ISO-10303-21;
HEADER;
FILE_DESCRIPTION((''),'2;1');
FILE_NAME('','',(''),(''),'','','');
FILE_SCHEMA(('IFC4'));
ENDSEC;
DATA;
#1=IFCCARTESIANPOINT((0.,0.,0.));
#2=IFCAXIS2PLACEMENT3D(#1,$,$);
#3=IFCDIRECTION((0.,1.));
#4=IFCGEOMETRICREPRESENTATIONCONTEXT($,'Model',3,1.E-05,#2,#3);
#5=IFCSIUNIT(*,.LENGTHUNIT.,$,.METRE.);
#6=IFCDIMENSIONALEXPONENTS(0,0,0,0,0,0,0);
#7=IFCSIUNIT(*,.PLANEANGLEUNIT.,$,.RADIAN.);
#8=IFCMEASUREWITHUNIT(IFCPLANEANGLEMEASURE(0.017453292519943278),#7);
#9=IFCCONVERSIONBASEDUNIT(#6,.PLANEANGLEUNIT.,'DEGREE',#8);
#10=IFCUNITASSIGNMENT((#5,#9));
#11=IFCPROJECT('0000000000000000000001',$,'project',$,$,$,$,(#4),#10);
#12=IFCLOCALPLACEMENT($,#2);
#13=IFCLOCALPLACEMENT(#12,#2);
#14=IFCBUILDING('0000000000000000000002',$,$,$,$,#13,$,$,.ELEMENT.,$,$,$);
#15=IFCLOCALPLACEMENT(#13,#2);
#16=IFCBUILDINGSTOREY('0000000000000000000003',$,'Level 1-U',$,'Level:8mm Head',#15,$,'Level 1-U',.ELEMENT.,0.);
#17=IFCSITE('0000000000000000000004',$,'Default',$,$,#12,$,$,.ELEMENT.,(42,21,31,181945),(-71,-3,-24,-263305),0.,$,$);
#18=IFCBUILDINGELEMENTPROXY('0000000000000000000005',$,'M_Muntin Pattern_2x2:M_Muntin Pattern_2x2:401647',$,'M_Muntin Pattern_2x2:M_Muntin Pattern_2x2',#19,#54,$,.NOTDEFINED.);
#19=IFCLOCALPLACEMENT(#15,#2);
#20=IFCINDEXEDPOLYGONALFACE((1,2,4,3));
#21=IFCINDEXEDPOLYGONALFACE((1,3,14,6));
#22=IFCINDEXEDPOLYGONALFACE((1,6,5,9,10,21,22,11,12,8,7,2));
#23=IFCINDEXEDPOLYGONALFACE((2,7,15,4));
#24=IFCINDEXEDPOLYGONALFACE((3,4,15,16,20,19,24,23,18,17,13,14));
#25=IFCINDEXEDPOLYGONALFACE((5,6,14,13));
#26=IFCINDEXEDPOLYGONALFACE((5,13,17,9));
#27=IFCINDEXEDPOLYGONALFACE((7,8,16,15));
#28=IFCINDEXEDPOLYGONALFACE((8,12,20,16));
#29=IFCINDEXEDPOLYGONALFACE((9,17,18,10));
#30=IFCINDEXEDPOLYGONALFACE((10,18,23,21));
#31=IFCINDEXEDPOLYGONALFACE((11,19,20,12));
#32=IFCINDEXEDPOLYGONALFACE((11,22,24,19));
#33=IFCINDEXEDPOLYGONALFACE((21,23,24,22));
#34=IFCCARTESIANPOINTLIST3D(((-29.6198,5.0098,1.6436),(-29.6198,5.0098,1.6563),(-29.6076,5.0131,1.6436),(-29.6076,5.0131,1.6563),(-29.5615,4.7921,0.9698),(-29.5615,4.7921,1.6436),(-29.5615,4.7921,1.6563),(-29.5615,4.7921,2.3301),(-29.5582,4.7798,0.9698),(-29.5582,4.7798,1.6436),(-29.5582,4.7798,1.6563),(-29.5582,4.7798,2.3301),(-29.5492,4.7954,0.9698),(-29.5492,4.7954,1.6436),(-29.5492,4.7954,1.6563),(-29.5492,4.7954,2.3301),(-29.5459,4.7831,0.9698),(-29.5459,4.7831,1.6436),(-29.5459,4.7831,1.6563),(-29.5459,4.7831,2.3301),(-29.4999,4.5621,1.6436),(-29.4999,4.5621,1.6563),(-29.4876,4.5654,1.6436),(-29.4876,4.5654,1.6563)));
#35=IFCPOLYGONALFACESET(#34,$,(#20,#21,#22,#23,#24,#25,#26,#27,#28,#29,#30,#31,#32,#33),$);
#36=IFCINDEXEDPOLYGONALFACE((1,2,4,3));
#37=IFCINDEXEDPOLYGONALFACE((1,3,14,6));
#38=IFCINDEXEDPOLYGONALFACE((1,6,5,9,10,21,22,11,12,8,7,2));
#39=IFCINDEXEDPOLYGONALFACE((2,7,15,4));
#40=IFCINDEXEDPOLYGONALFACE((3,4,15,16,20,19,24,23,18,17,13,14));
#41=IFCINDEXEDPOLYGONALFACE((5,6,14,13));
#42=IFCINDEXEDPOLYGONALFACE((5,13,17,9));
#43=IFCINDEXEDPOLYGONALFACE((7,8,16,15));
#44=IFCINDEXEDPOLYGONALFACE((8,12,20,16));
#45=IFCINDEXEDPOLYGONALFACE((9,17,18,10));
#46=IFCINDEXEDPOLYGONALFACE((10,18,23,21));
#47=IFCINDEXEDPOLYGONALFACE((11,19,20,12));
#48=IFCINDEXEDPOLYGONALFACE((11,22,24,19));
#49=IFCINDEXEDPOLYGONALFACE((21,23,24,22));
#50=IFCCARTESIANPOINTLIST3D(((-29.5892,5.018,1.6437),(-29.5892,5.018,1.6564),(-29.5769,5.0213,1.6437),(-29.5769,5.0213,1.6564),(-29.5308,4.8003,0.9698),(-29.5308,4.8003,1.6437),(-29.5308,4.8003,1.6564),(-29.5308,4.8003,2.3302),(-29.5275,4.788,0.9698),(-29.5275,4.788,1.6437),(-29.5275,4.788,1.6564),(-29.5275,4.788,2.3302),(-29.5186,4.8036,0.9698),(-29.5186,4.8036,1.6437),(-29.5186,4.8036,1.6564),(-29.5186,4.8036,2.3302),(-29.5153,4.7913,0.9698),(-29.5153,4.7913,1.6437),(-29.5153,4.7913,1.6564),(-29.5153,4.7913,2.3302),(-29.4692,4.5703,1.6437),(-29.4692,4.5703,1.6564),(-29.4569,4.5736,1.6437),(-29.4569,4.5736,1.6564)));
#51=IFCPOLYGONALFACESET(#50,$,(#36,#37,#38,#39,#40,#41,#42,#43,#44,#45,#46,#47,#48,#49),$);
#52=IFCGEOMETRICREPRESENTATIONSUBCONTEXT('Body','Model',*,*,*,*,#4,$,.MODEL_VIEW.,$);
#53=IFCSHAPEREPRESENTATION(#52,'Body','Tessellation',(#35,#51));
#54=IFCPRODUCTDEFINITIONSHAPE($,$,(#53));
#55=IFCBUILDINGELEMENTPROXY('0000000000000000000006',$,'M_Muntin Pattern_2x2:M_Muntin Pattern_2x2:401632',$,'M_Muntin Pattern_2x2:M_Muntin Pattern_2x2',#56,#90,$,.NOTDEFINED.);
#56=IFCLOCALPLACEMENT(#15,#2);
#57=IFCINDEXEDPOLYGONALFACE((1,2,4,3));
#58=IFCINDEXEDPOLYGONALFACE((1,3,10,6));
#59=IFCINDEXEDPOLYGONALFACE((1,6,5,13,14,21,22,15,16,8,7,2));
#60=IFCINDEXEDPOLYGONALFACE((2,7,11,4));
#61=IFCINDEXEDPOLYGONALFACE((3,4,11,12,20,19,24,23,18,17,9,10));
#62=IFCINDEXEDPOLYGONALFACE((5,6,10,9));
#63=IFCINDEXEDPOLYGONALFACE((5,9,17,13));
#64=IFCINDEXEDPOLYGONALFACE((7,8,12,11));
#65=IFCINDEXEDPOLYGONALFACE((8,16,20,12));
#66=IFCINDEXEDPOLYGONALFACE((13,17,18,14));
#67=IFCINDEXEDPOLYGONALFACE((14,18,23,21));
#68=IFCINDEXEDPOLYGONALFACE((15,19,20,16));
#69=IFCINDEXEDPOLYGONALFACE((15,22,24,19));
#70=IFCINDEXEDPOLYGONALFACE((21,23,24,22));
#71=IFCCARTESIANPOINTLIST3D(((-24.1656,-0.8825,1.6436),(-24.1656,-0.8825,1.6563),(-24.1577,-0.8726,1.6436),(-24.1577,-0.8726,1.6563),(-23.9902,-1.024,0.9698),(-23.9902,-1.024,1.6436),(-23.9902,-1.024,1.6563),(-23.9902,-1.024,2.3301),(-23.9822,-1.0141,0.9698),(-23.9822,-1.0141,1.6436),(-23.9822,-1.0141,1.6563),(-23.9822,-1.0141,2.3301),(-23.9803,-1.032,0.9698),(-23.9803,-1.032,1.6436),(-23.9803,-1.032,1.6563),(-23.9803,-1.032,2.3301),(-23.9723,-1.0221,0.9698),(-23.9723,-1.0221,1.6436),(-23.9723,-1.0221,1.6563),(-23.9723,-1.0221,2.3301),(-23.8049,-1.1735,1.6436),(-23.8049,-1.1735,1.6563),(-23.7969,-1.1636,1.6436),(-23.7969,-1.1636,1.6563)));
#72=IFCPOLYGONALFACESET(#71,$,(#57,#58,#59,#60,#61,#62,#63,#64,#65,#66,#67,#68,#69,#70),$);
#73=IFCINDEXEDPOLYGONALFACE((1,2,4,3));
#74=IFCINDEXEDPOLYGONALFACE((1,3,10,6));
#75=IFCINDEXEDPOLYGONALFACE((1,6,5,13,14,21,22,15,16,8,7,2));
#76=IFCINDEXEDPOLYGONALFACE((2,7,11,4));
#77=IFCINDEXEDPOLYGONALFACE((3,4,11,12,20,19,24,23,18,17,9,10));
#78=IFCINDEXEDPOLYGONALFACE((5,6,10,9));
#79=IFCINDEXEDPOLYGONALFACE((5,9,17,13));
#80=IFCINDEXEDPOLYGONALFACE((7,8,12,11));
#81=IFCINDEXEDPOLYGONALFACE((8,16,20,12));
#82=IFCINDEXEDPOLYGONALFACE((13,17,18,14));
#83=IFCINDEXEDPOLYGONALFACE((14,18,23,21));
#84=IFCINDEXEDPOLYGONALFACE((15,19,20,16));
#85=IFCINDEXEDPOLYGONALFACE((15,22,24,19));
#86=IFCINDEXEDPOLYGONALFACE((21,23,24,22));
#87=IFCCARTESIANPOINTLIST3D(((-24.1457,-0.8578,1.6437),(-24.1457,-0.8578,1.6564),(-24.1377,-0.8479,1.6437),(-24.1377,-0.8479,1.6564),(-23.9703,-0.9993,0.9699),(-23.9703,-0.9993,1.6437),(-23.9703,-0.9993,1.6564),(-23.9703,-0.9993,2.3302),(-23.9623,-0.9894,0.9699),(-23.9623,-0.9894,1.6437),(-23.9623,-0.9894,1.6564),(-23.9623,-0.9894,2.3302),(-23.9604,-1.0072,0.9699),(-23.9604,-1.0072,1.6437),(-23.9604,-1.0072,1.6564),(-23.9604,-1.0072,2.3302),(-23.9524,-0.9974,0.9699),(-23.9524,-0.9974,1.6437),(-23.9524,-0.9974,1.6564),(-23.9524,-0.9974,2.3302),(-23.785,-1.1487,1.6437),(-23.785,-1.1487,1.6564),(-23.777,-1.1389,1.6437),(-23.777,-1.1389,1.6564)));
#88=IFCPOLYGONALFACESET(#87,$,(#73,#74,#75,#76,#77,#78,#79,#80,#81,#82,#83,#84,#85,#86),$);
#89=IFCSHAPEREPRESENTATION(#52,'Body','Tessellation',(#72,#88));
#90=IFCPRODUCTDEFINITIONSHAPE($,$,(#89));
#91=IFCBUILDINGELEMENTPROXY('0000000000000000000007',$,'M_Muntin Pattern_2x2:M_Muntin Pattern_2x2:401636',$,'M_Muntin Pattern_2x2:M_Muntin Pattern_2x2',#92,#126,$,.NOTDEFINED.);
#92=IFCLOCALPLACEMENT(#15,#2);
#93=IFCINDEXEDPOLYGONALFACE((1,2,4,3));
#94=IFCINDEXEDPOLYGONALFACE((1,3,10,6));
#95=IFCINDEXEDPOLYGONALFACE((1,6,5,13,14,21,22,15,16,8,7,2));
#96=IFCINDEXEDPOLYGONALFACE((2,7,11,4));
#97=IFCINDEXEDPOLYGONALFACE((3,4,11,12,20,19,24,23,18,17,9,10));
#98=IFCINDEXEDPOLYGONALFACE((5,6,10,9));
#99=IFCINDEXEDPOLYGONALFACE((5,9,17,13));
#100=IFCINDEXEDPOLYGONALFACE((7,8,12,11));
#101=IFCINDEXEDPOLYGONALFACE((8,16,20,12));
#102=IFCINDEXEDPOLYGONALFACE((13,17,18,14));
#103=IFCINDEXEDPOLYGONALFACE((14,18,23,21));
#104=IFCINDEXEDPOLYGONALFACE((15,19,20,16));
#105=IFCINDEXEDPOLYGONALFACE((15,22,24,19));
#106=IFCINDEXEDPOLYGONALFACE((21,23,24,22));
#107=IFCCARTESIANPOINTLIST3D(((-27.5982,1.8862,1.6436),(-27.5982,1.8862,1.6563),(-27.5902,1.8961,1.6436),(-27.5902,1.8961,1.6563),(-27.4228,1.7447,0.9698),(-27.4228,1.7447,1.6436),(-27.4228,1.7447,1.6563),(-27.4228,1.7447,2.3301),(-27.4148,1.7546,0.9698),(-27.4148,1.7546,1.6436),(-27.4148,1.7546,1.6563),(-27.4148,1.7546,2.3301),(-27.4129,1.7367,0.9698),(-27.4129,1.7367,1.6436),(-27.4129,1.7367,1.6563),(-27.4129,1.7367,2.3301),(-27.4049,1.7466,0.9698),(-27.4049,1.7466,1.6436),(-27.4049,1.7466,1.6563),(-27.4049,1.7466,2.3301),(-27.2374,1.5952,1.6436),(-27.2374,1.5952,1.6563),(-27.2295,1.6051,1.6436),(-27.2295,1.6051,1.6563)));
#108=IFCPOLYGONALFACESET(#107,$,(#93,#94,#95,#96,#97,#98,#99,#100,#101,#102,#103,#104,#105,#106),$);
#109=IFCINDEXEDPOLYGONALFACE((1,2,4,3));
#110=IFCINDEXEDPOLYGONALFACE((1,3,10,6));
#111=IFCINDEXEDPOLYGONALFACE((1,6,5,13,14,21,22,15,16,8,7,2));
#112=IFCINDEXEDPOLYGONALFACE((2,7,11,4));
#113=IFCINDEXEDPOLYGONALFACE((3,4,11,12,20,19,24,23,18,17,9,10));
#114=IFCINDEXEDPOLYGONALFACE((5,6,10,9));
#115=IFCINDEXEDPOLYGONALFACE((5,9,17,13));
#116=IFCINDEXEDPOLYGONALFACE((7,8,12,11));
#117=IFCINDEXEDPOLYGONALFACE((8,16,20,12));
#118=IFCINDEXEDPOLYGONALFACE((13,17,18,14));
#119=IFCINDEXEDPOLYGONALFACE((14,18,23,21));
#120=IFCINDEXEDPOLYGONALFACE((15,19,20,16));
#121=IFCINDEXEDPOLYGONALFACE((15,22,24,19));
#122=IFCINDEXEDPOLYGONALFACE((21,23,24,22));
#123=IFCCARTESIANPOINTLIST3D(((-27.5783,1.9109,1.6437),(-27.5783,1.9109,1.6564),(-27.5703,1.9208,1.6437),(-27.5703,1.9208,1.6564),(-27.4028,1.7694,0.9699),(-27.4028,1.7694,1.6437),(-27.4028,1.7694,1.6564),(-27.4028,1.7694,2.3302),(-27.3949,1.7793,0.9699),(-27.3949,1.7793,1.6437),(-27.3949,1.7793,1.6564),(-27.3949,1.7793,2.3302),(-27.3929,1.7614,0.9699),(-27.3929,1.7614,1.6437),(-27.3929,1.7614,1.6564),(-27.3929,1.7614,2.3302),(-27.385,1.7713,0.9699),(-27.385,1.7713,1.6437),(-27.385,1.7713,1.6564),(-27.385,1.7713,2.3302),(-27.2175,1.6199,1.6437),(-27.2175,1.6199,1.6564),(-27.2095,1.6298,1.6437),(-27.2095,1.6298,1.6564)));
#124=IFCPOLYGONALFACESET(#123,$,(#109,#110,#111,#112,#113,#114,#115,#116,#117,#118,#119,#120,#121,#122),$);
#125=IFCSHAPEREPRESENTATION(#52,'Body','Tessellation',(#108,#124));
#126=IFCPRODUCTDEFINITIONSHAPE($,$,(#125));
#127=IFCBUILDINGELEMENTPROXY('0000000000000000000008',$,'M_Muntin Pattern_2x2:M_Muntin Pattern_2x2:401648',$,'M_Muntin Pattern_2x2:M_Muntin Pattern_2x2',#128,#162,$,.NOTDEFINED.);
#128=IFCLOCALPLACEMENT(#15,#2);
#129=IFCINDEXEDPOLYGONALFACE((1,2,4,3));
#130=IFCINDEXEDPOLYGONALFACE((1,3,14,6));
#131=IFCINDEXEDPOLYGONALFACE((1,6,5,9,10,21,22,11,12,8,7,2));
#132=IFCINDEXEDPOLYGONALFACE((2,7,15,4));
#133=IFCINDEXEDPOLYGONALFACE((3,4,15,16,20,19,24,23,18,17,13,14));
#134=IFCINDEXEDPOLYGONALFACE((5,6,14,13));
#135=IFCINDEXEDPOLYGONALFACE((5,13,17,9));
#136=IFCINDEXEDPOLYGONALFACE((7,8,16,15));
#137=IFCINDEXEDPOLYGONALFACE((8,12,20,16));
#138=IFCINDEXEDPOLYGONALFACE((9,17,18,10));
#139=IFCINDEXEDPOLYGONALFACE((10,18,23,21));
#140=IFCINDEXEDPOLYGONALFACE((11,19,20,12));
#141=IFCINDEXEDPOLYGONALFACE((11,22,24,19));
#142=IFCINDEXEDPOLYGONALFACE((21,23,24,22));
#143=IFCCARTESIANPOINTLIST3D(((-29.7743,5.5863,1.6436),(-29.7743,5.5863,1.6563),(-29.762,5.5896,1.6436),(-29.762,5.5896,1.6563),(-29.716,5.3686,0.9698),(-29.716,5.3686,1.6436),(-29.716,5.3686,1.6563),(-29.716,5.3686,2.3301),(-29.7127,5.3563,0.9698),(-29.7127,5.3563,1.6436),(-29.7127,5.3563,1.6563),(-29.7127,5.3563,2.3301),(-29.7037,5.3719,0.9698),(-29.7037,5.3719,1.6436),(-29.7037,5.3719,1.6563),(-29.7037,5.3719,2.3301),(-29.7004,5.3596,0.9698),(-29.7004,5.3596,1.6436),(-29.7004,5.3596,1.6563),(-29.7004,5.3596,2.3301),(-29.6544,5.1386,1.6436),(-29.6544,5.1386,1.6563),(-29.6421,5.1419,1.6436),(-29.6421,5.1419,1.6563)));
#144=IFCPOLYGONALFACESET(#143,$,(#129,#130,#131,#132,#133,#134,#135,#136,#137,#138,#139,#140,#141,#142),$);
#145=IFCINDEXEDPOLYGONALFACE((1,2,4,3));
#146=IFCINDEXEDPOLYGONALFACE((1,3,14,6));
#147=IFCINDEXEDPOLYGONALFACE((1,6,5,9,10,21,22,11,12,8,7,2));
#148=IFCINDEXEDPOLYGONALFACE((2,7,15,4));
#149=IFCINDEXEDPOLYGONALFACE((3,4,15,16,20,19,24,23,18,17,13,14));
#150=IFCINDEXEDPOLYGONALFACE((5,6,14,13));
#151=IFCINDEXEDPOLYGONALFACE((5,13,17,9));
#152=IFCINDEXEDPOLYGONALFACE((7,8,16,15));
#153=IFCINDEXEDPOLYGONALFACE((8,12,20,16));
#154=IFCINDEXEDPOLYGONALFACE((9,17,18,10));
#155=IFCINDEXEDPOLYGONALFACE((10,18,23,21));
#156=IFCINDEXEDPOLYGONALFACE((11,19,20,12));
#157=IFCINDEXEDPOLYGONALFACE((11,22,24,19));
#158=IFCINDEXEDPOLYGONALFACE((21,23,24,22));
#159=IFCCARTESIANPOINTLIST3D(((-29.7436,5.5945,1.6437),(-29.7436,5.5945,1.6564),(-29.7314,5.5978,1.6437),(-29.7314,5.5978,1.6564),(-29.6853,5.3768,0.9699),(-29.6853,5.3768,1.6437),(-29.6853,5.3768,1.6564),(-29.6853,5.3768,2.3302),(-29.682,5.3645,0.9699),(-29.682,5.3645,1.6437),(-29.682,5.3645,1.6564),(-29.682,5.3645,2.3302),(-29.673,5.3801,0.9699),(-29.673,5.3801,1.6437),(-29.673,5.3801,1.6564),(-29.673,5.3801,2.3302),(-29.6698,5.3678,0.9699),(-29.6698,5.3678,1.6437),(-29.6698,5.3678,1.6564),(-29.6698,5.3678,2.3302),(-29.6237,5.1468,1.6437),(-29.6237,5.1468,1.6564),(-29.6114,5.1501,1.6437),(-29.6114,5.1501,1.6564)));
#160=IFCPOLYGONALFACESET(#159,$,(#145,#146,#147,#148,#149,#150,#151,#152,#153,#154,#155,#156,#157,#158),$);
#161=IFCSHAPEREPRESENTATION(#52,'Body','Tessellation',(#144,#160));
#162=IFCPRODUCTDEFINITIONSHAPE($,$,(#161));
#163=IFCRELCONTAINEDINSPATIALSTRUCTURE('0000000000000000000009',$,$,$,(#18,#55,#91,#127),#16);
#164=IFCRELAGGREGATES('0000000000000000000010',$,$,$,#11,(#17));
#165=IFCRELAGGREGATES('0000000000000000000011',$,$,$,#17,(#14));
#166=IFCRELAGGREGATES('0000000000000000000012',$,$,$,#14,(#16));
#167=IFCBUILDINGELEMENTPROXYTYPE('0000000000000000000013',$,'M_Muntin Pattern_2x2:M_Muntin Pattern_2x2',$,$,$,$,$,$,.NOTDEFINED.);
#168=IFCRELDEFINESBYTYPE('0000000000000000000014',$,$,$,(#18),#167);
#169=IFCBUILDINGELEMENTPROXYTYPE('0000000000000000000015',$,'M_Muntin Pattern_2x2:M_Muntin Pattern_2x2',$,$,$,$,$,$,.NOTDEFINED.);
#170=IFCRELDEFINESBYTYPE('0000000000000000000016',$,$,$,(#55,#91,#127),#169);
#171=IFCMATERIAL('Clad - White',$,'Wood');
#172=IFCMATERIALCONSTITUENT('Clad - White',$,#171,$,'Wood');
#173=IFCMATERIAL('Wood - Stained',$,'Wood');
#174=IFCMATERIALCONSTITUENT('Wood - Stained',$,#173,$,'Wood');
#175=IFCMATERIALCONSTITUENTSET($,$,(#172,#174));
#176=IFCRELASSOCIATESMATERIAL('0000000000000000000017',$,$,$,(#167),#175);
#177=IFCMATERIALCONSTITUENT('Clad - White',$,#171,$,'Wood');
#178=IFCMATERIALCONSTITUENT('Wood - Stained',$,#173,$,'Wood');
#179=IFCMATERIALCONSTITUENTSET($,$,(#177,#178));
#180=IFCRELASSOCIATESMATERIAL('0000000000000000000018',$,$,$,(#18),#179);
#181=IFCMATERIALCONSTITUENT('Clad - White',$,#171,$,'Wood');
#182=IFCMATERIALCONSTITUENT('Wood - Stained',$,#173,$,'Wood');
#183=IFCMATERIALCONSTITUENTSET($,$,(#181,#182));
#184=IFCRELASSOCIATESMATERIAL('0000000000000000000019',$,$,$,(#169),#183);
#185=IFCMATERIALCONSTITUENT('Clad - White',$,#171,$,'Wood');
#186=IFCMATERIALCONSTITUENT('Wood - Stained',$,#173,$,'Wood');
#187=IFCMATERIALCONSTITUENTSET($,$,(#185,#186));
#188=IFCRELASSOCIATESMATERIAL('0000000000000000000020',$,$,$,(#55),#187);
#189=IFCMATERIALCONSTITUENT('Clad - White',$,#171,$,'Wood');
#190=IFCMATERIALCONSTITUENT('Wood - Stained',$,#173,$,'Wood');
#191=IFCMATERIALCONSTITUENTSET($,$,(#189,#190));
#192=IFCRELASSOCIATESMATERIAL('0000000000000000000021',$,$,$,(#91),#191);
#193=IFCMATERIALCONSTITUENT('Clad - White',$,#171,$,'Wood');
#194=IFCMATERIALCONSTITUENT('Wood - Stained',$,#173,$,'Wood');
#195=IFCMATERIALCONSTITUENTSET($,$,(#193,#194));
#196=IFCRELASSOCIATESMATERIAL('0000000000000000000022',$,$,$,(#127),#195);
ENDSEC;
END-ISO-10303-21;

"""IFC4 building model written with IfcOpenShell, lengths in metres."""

from ifc_helpers import new_model, entity, si_unit, converted_unit, direction, frame, origin, place, context, subcontext, project, spatial, polyline, outline, extrude, source, transform, mapped, material, constituent, constituent_set, type_object, type_shapes, element, save


model = new_model("IFC4")

# Units and contexts
model_context = context("Model", 3, precision=1e-05, world=origin(), true_north=direction((0.0, 1.0)))
body_context = subcontext(model_context, "Body", "Model", "MODEL_VIEW")
ifc_project = project(units=[si_unit("LENGTHUNIT", "METRE"), converted_unit("PLANEANGLEUNIT", "DEGREE", entity("IfcPlaneAngleMeasure", 0.017453292519943278), si_unit("PLANEANGLEUNIT", "RADIAN"), dimensions=[0, 0, 0, 0, 0, 0, 0])], contexts=[model_context])

# Site, building, storey
site_placement = place(None, origin())
site = spatial("IfcSite", under=ifc_project, at=site_placement, Name="Default", CompositionType="ELEMENT", RefLatitude=(42, 21, 31, 181945), RefLongitude=(-71, -3, -24, -263305), RefElevation=0.0)
building_placement = place(site_placement, origin())
building = spatial("IfcBuilding", under=site, at=building_placement, CompositionType="ELEMENT")
storey_placement = place(building_placement, origin())
storey = spatial("IfcBuildingStorey", under=building, at=storey_placement, Name="Level 1-U", ObjectType="Level:8mm Head", LongName="Level 1-U", CompositionType="ELEMENT", Elevation=0.0)

# Building element proxies
ifc_material_1 = material(Name="Clad - White", Category="Wood")
ifc_material_2 = material(Name="Wood - Stained", Category="Wood")
ifc_constituent_1 = constituent(ifc_material_1, Name="Clad - White", Category="Wood")
ifc_constituent_2 = constituent(ifc_material_2, Name="Wood - Stained", Category="Wood")
ifc_constituent_set_1 = constituent_set(constituents=[ifc_constituent_1, ifc_constituent_2])
building_element_proxy_type_1 = type_object("IfcBuildingElementProxyType", Name="M_Muntin Pattern_2x2:M_Muntin Pattern_2x2", PredefinedType="NOTDEFINED", material=ifc_constituent_set_1)
shared_shape_1 = source(origin(), body_context, "Body", "SweptSolid", [
    extrude(outline(polyline([(0.0064, -0.0064), (0.6801, -0.0064), (0.6801, 0.0063), (0.0064, 0.0063), (0.0064, 0.2317), (-0.0063, 0.2317), (-0.0063, 0.0063), (-0.6802, 0.0063), (-0.6802, -0.0064), (-0.0063, -0.0064), (-0.0063, -0.2317), (0.0064, -0.2317), (0.0064, -0.0064)])), frame((0.0, 0.0095, 0.6801), z_axis=(0.0, 1.0, 0.0), x_axis=(0.0, 0.0, 1.0)), (0.0, 0.0, 1.0), 0.0127),
    extrude(outline(polyline([(0.0064, -0.0064), (0.6802, -0.0064), (0.6802, 0.0063), (0.0064, 0.0063), (0.0064, 0.2317), (-0.0063, 0.2317), (-0.0063, 0.0063), (-0.6802, 0.0063), (-0.6802, -0.0064), (-0.0063, -0.0064), (-0.0063, -0.2317), (0.0064, -0.2317), (0.0064, -0.0064)])), frame((0.0, -0.0222, 0.6802), z_axis=(0.0, 1.0, 0.0), x_axis=(0.0, 0.0, 1.0)), (0.0, 0.0, 1.0), 0.0127),
])
type_shapes(building_element_proxy_type_1, [shared_shape_1])
ifc_constituent_3 = constituent(ifc_material_1, Name="Clad - White", Category="Wood")
ifc_constituent_4 = constituent(ifc_material_2, Name="Wood - Stained", Category="Wood")
ifc_constituent_set_2 = constituent_set(constituents=[ifc_constituent_3, ifc_constituent_4])
proxy_1_placement = place(storey_placement, frame((-29.5384, 4.7917, 0.9698), z_axis=(0.0, 0.0, 1.0), x_axis=(-0.258819, 0.965926, 0.0)))
element("IfcBuildingElementProxy", 1, at=proxy_1_placement, inside=storey, type_object=building_element_proxy_type_1, material=ifc_constituent_set_2, Name="M_Muntin Pattern_2x2:M_Muntin Pattern_2x2:401647", ObjectType="M_Muntin Pattern_2x2:M_Muntin Pattern_2x2", PredefinedType="NOTDEFINED", context=body_context, shape_type="MappedRepresentation", body=[
    mapped(shared_shape_1, transform((0.0, 0.0, 0.0), scale=1.0)),
])
ifc_constituent_5 = constituent(ifc_material_1, Name="Clad - White", Category="Wood")
ifc_constituent_6 = constituent(ifc_material_2, Name="Wood - Stained", Category="Wood")
ifc_constituent_set_3 = constituent_set(constituents=[ifc_constituent_5, ifc_constituent_6])
ifc_constituent_7 = constituent(ifc_material_1, Name="Clad - White", Category="Wood")
ifc_constituent_8 = constituent(ifc_material_2, Name="Wood - Stained", Category="Wood")
ifc_constituent_set_4 = constituent_set(constituents=[ifc_constituent_7, ifc_constituent_8])
building_element_proxy_type_2 = type_object("IfcBuildingElementProxyType", Name="M_Muntin Pattern_2x2:M_Muntin Pattern_2x2", PredefinedType="NOTDEFINED", material=ifc_constituent_set_4)
shared_shape_2 = source(origin(), body_context, "Body", "SweptSolid", [
    extrude(outline(polyline([(0.0064, -0.0064), (0.6801, -0.0064), (0.6801, 0.0063), (0.0064, 0.0063), (0.0064, 0.2317), (-0.0063, 0.2317), (-0.0063, 0.0063), (-0.6802, 0.0063), (-0.6802, -0.0064), (-0.0063, -0.0064), (-0.0063, -0.2317), (0.0064, -0.2317), (0.0064, -0.0064)])), frame((0.0, -0.0222, 0.6801), z_axis=(0.0, 1.0, 0.0), x_axis=(0.0, 0.0, 1.0)), (0.0, 0.0, 1.0), 0.0127),
    extrude(outline(polyline([(0.0064, -0.0064), (0.6802, -0.0064), (0.6802, 0.0063), (0.0064, 0.0063), (0.0064, 0.2317), (-0.0063, 0.2317), (-0.0063, 0.0063), (-0.6802, 0.0063), (-0.6802, -0.0064), (-0.0063, -0.0064), (-0.0063, -0.2317), (0.0064, -0.2317), (0.0064, -0.0064)])), frame((0.0, 0.0095, 0.6802), z_axis=(0.0, 1.0, 0.0), x_axis=(0.0, 0.0, 1.0)), (0.0, 0.0, 1.0), 0.0127),
])
type_shapes(building_element_proxy_type_2, [shared_shape_2])
proxy_2_placement = place(storey_placement, frame((-23.9713, -1.0107, 0.9699), z_axis=(0.0, 0.0, 1.0), x_axis=(0.778359, -0.62782, 0.0)))
element("IfcBuildingElementProxy", 2, at=proxy_2_placement, inside=storey, type_object=building_element_proxy_type_2, material=ifc_constituent_set_3, Name="M_Muntin Pattern_2x2:M_Muntin Pattern_2x2:401632", ObjectType="M_Muntin Pattern_2x2:M_Muntin Pattern_2x2", PredefinedType="NOTDEFINED", context=body_context, shape_type="MappedRepresentation", body=[
    mapped(shared_shape_2, transform((0.0, 0.0, 0.0), scale=1.0)),
])
ifc_constituent_9 = constituent(ifc_material_1, Name="Clad - White", Category="Wood")
ifc_constituent_10 = constituent(ifc_material_2, Name="Wood - Stained", Category="Wood")
ifc_constituent_set_5 = constituent_set(constituents=[ifc_constituent_9, ifc_constituent_10])
proxy_3_placement = place(storey_placement, frame((-27.4039, 1.758, 0.9699), z_axis=(0.0, 0.0, 1.0), x_axis=(0.778359, -0.62782, 0.0)))
element("IfcBuildingElementProxy", 3, at=proxy_3_placement, inside=storey, type_object=building_element_proxy_type_2, material=ifc_constituent_set_5, Name="M_Muntin Pattern_2x2:M_Muntin Pattern_2x2:401636", ObjectType="M_Muntin Pattern_2x2:M_Muntin Pattern_2x2", PredefinedType="NOTDEFINED", context=body_context, shape_type="MappedRepresentation", body=[
    mapped(shared_shape_2, transform((0.0, 0.0, 0.0), scale=1.0)),
])
ifc_constituent_11 = constituent(ifc_material_1, Name="Clad - White", Category="Wood")
ifc_constituent_12 = constituent(ifc_material_2, Name="Wood - Stained", Category="Wood")
ifc_constituent_set_6 = constituent_set(constituents=[ifc_constituent_11, ifc_constituent_12])
proxy_4_placement = place(storey_placement, frame((-29.6929, 5.3682, 0.9699), z_axis=(0.0, 0.0, 1.0), x_axis=(0.258819, -0.965926, 0.0)))
element("IfcBuildingElementProxy", 4, at=proxy_4_placement, inside=storey, type_object=building_element_proxy_type_2, material=ifc_constituent_set_6, Name="M_Muntin Pattern_2x2:M_Muntin Pattern_2x2:401648", ObjectType="M_Muntin Pattern_2x2:M_Muntin Pattern_2x2", PredefinedType="NOTDEFINED", context=body_context, shape_type="MappedRepresentation", body=[
    mapped(shared_shape_2, transform((0.0, 0.0, 0.0), scale=1.0)),
])

save(model, "model.ifc")
